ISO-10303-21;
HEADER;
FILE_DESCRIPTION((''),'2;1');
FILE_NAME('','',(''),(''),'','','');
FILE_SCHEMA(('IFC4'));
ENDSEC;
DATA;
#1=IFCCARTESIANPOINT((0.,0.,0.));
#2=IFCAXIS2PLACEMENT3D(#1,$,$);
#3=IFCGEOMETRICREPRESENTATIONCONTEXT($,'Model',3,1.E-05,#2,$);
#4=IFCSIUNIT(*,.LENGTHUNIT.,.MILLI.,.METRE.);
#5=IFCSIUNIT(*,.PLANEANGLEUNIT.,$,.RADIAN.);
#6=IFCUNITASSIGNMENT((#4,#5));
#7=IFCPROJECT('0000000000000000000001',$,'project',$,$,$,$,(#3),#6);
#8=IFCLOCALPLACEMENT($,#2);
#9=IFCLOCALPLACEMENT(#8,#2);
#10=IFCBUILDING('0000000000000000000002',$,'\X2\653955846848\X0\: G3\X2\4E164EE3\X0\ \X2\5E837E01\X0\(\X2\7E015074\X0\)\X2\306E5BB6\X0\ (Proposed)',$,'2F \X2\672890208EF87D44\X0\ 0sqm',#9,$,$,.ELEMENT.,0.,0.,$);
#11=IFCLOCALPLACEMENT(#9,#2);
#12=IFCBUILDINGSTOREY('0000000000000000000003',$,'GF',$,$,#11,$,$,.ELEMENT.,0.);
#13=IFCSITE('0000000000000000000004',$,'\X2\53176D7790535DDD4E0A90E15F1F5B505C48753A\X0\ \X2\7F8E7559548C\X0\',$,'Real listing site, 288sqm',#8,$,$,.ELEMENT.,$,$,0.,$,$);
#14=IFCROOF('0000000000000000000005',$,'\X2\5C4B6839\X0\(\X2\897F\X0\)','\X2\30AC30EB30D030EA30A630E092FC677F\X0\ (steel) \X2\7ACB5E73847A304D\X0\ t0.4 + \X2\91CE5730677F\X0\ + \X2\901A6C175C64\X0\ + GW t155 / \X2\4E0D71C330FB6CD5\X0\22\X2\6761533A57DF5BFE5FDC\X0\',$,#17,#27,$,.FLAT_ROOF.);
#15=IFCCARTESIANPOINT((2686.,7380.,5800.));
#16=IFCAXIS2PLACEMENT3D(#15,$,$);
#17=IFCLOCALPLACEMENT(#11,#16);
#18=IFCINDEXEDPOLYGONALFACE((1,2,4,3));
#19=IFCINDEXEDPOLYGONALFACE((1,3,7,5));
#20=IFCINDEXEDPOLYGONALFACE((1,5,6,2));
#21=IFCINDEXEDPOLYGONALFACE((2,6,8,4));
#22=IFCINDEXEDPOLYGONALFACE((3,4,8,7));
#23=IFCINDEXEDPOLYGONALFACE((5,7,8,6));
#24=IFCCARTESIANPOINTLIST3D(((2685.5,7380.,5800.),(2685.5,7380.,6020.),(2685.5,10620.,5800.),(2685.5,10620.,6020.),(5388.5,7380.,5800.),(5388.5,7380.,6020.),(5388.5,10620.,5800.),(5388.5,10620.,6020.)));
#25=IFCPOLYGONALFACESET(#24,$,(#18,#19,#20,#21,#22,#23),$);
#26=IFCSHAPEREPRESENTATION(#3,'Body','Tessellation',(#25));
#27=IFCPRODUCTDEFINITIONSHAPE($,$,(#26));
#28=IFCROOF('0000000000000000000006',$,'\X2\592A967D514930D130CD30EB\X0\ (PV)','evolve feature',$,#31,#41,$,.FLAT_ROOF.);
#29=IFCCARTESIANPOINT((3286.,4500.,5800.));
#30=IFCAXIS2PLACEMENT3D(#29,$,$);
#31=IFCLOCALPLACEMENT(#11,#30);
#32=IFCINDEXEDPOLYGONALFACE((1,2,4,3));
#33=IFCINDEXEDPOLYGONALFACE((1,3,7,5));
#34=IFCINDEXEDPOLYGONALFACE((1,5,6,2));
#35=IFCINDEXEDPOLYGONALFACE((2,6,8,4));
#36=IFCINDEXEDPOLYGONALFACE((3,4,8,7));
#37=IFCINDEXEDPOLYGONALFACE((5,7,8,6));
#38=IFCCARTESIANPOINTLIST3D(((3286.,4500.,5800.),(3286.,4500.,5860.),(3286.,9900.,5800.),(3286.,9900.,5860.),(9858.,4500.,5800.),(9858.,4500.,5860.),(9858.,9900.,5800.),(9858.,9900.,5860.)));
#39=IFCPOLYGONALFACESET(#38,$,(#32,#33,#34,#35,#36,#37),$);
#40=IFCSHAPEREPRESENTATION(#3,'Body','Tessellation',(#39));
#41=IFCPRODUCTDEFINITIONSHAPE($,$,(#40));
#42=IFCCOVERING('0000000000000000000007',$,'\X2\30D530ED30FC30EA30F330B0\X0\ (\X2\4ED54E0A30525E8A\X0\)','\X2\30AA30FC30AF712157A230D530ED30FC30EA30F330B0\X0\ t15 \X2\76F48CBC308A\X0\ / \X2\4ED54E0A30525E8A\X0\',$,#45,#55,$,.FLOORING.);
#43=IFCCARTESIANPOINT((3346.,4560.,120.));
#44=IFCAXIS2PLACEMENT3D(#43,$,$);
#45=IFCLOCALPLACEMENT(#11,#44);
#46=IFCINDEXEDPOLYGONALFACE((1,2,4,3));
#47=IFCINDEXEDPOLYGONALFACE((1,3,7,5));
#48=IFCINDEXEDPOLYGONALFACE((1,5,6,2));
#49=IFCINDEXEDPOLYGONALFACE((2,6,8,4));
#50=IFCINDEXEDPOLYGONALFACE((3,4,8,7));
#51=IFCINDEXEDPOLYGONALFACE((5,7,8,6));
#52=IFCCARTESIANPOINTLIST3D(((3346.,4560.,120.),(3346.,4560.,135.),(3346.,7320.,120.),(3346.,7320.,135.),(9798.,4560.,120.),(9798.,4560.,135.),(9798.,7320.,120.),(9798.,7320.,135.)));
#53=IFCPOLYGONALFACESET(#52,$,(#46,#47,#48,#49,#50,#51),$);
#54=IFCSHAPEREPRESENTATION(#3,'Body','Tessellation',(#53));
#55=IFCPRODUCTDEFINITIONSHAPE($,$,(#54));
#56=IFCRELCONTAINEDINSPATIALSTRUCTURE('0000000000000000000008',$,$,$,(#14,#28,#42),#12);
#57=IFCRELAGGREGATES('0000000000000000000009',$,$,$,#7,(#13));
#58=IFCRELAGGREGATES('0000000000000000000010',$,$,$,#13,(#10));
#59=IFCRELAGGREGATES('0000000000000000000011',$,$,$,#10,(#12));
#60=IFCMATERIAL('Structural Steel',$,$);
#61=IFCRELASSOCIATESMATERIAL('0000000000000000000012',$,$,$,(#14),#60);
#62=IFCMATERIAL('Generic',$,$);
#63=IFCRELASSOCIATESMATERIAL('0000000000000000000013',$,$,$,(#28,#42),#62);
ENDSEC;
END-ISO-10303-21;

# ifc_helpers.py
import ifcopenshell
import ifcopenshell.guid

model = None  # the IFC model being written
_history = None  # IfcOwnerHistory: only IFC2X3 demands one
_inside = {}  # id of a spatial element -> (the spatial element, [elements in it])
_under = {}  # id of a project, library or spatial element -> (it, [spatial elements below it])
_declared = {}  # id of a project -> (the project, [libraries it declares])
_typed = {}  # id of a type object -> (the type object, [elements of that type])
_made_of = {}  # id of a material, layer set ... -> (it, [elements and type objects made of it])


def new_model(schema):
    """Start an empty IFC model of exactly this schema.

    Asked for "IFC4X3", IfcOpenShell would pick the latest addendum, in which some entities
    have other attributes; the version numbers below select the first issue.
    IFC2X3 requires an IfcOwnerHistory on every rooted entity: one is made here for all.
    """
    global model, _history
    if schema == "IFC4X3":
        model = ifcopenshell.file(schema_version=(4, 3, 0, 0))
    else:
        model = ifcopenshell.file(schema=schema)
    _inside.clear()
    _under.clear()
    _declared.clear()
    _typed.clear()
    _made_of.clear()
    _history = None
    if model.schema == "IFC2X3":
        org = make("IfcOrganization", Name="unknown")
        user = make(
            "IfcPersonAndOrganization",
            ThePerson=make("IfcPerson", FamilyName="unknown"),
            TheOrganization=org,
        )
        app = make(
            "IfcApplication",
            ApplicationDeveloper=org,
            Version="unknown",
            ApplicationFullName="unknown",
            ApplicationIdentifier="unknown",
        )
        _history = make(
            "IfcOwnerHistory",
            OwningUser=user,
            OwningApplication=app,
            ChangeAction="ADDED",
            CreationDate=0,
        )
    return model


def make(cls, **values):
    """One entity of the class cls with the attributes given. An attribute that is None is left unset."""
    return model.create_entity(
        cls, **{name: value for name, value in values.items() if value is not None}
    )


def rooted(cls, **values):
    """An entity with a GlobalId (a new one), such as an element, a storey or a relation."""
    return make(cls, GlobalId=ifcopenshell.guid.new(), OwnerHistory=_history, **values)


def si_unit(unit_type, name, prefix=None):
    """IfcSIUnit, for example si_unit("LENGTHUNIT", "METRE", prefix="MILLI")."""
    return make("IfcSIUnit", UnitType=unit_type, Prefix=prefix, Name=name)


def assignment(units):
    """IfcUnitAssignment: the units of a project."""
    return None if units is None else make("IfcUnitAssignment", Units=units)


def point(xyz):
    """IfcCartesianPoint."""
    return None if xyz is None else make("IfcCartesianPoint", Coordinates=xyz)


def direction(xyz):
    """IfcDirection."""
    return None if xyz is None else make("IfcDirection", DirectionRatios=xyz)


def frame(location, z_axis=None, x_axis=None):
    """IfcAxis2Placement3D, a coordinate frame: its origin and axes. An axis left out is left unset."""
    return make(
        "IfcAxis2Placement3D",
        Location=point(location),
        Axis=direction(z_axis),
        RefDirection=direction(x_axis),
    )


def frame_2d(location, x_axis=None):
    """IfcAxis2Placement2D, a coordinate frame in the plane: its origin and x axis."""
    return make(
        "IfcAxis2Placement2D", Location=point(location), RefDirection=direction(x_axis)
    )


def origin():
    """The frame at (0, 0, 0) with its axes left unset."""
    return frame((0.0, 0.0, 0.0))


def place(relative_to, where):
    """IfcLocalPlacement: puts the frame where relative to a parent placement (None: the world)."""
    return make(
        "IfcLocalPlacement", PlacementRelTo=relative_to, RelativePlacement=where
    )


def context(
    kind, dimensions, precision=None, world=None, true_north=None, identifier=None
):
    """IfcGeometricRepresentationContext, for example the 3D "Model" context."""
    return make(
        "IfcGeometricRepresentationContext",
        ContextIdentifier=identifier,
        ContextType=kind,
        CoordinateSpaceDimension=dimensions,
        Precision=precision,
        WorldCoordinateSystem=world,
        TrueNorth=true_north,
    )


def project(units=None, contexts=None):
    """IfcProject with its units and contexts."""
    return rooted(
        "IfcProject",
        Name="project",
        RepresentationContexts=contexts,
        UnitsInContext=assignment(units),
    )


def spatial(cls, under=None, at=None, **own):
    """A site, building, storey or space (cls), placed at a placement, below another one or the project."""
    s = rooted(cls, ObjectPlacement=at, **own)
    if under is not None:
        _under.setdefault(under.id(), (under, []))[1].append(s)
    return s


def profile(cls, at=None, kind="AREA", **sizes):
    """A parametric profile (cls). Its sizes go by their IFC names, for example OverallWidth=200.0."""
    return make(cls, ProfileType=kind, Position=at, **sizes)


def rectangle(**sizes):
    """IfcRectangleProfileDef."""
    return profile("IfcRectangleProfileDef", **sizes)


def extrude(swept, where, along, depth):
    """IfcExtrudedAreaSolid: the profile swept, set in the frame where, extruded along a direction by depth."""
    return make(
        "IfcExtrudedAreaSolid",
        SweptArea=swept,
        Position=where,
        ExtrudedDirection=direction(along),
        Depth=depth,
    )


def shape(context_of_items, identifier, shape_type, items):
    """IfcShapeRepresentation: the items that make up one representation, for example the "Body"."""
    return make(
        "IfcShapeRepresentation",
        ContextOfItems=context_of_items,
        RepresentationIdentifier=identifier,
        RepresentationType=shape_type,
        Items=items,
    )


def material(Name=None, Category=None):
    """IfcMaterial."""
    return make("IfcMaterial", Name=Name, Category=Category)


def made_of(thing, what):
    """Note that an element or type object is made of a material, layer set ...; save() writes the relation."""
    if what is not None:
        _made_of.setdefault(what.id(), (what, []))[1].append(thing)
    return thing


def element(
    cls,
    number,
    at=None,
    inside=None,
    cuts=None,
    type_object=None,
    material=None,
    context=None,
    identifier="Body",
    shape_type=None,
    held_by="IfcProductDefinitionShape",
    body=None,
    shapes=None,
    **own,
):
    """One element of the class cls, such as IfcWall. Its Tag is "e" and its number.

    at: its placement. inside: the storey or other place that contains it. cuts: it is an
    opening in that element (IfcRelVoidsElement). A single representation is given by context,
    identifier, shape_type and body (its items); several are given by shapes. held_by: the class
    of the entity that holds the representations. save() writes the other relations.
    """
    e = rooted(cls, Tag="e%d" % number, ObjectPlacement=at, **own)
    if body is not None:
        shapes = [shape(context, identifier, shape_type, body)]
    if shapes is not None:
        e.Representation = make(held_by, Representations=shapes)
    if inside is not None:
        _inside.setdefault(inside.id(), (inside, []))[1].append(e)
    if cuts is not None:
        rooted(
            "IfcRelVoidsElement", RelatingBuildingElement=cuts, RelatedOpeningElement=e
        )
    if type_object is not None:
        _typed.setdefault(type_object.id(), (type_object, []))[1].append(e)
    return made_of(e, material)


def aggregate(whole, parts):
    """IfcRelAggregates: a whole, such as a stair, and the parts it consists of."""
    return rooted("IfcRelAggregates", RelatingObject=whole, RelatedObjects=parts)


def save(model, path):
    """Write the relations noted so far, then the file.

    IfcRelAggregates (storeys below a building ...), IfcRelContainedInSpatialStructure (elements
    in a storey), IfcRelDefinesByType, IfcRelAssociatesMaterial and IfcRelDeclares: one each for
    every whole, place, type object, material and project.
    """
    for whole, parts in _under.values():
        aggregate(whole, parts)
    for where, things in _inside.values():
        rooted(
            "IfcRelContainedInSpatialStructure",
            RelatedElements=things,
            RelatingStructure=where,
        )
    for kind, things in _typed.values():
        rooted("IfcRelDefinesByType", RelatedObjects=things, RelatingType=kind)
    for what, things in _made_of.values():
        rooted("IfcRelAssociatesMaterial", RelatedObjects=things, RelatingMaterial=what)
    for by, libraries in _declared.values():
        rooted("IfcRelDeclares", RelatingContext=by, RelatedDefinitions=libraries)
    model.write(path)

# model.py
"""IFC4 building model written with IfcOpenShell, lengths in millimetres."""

from ifc_helpers import new_model, si_unit, frame, frame_2d, origin, place, context, project, spatial, rectangle, extrude, material, element, save


model = new_model("IFC4")

# Units and contexts
model_context = context("Model", 3, precision=1e-05, world=origin())
ifc_project = project(units=[si_unit("LENGTHUNIT", "METRE", prefix="MILLI"), si_unit("PLANEANGLEUNIT", "RADIAN")], contexts=[model_context])

# Site, building, storey
site_placement = place(None, origin())
site = spatial("IfcSite", under=ifc_project, at=site_placement, Name="北海道川上郡弟子屈町 美留和", ObjectType="Real listing site, 288sqm", CompositionType="ELEMENT", RefElevation=0.0)
building_placement = place(site_placement, origin())
building = spatial("IfcBuilding", under=site, at=building_placement, Name="改善案: G3世代 広縁(縁側)の家 (Proposed)", ObjectType="2F 木造軸組 0sqm", CompositionType="ELEMENT", ElevationOfRefHeight=0.0, ElevationOfTerrain=0.0)
storey_placement = place(building_placement, origin())
storey = spatial("IfcBuildingStorey", under=building, at=storey_placement, Name="GF", CompositionType="ELEMENT", Elevation=0.0)

# Shared definitions
ifc_material_1 = material(Name="Generic")

# Roofs
ifc_material_2 = material(Name="Structural Steel")
roof_1_placement = place(storey_placement, frame((2686.0, 7380.0, 5800.0)))
element("IfcRoof", 1, at=roof_1_placement, inside=storey, material=ifc_material_2, Name="屋根(西)", Description="ガルバリウム鋼板 (steel) 立平葺き t0.4 + 野地板 + 通気層 + GW t155 / 不燃・法22条区域対応", PredefinedType="FLAT_ROOF", context=model_context, shape_type="SweptSolid", body=[
    extrude(rectangle(XDim=2703.0, YDim=3240.0, at=frame_2d((1351.0, 1620.0))), frame((2686.0, 7380.0, 5800.0)), (0.0, 0.0, 1.0), 220.0),
])
roof_2_placement = place(storey_placement, frame((3286.0, 4500.0, 5800.0)))
element("IfcRoof", 2, at=roof_2_placement, inside=storey, material=ifc_material_1, Name="太陽光パネル (PV)", Description="evolve feature", PredefinedType="FLAT_ROOF", context=model_context, shape_type="SweptSolid", body=[
    extrude(rectangle(XDim=6572.0, YDim=5400.0, at=frame_2d((3286.0, 2700.0))), frame((3286.0, 4500.0, 5800.0)), (0.0, 0.0, 1.0), 60.0),
])

# Covering
covering_placement = place(storey_placement, frame((3346.0, 4560.0, 120.0)))
element("IfcCovering", 3, at=covering_placement, inside=storey, material=ifc_material_1, Name="フローリング (仕上げ床)", Description="オーク無垢フローリング t15 直貼り / 仕上げ床", PredefinedType="FLOORING", context=model_context, shape_type="SweptSolid", body=[
    extrude(rectangle(XDim=6452.0, YDim=2760.0, at=frame_2d((3226.0, 1380.0))), frame((3346.0, 4560.0, 120.0)), (0.0, 0.0, 1.0), 15.0),
])

save(model, "model.ifc")
